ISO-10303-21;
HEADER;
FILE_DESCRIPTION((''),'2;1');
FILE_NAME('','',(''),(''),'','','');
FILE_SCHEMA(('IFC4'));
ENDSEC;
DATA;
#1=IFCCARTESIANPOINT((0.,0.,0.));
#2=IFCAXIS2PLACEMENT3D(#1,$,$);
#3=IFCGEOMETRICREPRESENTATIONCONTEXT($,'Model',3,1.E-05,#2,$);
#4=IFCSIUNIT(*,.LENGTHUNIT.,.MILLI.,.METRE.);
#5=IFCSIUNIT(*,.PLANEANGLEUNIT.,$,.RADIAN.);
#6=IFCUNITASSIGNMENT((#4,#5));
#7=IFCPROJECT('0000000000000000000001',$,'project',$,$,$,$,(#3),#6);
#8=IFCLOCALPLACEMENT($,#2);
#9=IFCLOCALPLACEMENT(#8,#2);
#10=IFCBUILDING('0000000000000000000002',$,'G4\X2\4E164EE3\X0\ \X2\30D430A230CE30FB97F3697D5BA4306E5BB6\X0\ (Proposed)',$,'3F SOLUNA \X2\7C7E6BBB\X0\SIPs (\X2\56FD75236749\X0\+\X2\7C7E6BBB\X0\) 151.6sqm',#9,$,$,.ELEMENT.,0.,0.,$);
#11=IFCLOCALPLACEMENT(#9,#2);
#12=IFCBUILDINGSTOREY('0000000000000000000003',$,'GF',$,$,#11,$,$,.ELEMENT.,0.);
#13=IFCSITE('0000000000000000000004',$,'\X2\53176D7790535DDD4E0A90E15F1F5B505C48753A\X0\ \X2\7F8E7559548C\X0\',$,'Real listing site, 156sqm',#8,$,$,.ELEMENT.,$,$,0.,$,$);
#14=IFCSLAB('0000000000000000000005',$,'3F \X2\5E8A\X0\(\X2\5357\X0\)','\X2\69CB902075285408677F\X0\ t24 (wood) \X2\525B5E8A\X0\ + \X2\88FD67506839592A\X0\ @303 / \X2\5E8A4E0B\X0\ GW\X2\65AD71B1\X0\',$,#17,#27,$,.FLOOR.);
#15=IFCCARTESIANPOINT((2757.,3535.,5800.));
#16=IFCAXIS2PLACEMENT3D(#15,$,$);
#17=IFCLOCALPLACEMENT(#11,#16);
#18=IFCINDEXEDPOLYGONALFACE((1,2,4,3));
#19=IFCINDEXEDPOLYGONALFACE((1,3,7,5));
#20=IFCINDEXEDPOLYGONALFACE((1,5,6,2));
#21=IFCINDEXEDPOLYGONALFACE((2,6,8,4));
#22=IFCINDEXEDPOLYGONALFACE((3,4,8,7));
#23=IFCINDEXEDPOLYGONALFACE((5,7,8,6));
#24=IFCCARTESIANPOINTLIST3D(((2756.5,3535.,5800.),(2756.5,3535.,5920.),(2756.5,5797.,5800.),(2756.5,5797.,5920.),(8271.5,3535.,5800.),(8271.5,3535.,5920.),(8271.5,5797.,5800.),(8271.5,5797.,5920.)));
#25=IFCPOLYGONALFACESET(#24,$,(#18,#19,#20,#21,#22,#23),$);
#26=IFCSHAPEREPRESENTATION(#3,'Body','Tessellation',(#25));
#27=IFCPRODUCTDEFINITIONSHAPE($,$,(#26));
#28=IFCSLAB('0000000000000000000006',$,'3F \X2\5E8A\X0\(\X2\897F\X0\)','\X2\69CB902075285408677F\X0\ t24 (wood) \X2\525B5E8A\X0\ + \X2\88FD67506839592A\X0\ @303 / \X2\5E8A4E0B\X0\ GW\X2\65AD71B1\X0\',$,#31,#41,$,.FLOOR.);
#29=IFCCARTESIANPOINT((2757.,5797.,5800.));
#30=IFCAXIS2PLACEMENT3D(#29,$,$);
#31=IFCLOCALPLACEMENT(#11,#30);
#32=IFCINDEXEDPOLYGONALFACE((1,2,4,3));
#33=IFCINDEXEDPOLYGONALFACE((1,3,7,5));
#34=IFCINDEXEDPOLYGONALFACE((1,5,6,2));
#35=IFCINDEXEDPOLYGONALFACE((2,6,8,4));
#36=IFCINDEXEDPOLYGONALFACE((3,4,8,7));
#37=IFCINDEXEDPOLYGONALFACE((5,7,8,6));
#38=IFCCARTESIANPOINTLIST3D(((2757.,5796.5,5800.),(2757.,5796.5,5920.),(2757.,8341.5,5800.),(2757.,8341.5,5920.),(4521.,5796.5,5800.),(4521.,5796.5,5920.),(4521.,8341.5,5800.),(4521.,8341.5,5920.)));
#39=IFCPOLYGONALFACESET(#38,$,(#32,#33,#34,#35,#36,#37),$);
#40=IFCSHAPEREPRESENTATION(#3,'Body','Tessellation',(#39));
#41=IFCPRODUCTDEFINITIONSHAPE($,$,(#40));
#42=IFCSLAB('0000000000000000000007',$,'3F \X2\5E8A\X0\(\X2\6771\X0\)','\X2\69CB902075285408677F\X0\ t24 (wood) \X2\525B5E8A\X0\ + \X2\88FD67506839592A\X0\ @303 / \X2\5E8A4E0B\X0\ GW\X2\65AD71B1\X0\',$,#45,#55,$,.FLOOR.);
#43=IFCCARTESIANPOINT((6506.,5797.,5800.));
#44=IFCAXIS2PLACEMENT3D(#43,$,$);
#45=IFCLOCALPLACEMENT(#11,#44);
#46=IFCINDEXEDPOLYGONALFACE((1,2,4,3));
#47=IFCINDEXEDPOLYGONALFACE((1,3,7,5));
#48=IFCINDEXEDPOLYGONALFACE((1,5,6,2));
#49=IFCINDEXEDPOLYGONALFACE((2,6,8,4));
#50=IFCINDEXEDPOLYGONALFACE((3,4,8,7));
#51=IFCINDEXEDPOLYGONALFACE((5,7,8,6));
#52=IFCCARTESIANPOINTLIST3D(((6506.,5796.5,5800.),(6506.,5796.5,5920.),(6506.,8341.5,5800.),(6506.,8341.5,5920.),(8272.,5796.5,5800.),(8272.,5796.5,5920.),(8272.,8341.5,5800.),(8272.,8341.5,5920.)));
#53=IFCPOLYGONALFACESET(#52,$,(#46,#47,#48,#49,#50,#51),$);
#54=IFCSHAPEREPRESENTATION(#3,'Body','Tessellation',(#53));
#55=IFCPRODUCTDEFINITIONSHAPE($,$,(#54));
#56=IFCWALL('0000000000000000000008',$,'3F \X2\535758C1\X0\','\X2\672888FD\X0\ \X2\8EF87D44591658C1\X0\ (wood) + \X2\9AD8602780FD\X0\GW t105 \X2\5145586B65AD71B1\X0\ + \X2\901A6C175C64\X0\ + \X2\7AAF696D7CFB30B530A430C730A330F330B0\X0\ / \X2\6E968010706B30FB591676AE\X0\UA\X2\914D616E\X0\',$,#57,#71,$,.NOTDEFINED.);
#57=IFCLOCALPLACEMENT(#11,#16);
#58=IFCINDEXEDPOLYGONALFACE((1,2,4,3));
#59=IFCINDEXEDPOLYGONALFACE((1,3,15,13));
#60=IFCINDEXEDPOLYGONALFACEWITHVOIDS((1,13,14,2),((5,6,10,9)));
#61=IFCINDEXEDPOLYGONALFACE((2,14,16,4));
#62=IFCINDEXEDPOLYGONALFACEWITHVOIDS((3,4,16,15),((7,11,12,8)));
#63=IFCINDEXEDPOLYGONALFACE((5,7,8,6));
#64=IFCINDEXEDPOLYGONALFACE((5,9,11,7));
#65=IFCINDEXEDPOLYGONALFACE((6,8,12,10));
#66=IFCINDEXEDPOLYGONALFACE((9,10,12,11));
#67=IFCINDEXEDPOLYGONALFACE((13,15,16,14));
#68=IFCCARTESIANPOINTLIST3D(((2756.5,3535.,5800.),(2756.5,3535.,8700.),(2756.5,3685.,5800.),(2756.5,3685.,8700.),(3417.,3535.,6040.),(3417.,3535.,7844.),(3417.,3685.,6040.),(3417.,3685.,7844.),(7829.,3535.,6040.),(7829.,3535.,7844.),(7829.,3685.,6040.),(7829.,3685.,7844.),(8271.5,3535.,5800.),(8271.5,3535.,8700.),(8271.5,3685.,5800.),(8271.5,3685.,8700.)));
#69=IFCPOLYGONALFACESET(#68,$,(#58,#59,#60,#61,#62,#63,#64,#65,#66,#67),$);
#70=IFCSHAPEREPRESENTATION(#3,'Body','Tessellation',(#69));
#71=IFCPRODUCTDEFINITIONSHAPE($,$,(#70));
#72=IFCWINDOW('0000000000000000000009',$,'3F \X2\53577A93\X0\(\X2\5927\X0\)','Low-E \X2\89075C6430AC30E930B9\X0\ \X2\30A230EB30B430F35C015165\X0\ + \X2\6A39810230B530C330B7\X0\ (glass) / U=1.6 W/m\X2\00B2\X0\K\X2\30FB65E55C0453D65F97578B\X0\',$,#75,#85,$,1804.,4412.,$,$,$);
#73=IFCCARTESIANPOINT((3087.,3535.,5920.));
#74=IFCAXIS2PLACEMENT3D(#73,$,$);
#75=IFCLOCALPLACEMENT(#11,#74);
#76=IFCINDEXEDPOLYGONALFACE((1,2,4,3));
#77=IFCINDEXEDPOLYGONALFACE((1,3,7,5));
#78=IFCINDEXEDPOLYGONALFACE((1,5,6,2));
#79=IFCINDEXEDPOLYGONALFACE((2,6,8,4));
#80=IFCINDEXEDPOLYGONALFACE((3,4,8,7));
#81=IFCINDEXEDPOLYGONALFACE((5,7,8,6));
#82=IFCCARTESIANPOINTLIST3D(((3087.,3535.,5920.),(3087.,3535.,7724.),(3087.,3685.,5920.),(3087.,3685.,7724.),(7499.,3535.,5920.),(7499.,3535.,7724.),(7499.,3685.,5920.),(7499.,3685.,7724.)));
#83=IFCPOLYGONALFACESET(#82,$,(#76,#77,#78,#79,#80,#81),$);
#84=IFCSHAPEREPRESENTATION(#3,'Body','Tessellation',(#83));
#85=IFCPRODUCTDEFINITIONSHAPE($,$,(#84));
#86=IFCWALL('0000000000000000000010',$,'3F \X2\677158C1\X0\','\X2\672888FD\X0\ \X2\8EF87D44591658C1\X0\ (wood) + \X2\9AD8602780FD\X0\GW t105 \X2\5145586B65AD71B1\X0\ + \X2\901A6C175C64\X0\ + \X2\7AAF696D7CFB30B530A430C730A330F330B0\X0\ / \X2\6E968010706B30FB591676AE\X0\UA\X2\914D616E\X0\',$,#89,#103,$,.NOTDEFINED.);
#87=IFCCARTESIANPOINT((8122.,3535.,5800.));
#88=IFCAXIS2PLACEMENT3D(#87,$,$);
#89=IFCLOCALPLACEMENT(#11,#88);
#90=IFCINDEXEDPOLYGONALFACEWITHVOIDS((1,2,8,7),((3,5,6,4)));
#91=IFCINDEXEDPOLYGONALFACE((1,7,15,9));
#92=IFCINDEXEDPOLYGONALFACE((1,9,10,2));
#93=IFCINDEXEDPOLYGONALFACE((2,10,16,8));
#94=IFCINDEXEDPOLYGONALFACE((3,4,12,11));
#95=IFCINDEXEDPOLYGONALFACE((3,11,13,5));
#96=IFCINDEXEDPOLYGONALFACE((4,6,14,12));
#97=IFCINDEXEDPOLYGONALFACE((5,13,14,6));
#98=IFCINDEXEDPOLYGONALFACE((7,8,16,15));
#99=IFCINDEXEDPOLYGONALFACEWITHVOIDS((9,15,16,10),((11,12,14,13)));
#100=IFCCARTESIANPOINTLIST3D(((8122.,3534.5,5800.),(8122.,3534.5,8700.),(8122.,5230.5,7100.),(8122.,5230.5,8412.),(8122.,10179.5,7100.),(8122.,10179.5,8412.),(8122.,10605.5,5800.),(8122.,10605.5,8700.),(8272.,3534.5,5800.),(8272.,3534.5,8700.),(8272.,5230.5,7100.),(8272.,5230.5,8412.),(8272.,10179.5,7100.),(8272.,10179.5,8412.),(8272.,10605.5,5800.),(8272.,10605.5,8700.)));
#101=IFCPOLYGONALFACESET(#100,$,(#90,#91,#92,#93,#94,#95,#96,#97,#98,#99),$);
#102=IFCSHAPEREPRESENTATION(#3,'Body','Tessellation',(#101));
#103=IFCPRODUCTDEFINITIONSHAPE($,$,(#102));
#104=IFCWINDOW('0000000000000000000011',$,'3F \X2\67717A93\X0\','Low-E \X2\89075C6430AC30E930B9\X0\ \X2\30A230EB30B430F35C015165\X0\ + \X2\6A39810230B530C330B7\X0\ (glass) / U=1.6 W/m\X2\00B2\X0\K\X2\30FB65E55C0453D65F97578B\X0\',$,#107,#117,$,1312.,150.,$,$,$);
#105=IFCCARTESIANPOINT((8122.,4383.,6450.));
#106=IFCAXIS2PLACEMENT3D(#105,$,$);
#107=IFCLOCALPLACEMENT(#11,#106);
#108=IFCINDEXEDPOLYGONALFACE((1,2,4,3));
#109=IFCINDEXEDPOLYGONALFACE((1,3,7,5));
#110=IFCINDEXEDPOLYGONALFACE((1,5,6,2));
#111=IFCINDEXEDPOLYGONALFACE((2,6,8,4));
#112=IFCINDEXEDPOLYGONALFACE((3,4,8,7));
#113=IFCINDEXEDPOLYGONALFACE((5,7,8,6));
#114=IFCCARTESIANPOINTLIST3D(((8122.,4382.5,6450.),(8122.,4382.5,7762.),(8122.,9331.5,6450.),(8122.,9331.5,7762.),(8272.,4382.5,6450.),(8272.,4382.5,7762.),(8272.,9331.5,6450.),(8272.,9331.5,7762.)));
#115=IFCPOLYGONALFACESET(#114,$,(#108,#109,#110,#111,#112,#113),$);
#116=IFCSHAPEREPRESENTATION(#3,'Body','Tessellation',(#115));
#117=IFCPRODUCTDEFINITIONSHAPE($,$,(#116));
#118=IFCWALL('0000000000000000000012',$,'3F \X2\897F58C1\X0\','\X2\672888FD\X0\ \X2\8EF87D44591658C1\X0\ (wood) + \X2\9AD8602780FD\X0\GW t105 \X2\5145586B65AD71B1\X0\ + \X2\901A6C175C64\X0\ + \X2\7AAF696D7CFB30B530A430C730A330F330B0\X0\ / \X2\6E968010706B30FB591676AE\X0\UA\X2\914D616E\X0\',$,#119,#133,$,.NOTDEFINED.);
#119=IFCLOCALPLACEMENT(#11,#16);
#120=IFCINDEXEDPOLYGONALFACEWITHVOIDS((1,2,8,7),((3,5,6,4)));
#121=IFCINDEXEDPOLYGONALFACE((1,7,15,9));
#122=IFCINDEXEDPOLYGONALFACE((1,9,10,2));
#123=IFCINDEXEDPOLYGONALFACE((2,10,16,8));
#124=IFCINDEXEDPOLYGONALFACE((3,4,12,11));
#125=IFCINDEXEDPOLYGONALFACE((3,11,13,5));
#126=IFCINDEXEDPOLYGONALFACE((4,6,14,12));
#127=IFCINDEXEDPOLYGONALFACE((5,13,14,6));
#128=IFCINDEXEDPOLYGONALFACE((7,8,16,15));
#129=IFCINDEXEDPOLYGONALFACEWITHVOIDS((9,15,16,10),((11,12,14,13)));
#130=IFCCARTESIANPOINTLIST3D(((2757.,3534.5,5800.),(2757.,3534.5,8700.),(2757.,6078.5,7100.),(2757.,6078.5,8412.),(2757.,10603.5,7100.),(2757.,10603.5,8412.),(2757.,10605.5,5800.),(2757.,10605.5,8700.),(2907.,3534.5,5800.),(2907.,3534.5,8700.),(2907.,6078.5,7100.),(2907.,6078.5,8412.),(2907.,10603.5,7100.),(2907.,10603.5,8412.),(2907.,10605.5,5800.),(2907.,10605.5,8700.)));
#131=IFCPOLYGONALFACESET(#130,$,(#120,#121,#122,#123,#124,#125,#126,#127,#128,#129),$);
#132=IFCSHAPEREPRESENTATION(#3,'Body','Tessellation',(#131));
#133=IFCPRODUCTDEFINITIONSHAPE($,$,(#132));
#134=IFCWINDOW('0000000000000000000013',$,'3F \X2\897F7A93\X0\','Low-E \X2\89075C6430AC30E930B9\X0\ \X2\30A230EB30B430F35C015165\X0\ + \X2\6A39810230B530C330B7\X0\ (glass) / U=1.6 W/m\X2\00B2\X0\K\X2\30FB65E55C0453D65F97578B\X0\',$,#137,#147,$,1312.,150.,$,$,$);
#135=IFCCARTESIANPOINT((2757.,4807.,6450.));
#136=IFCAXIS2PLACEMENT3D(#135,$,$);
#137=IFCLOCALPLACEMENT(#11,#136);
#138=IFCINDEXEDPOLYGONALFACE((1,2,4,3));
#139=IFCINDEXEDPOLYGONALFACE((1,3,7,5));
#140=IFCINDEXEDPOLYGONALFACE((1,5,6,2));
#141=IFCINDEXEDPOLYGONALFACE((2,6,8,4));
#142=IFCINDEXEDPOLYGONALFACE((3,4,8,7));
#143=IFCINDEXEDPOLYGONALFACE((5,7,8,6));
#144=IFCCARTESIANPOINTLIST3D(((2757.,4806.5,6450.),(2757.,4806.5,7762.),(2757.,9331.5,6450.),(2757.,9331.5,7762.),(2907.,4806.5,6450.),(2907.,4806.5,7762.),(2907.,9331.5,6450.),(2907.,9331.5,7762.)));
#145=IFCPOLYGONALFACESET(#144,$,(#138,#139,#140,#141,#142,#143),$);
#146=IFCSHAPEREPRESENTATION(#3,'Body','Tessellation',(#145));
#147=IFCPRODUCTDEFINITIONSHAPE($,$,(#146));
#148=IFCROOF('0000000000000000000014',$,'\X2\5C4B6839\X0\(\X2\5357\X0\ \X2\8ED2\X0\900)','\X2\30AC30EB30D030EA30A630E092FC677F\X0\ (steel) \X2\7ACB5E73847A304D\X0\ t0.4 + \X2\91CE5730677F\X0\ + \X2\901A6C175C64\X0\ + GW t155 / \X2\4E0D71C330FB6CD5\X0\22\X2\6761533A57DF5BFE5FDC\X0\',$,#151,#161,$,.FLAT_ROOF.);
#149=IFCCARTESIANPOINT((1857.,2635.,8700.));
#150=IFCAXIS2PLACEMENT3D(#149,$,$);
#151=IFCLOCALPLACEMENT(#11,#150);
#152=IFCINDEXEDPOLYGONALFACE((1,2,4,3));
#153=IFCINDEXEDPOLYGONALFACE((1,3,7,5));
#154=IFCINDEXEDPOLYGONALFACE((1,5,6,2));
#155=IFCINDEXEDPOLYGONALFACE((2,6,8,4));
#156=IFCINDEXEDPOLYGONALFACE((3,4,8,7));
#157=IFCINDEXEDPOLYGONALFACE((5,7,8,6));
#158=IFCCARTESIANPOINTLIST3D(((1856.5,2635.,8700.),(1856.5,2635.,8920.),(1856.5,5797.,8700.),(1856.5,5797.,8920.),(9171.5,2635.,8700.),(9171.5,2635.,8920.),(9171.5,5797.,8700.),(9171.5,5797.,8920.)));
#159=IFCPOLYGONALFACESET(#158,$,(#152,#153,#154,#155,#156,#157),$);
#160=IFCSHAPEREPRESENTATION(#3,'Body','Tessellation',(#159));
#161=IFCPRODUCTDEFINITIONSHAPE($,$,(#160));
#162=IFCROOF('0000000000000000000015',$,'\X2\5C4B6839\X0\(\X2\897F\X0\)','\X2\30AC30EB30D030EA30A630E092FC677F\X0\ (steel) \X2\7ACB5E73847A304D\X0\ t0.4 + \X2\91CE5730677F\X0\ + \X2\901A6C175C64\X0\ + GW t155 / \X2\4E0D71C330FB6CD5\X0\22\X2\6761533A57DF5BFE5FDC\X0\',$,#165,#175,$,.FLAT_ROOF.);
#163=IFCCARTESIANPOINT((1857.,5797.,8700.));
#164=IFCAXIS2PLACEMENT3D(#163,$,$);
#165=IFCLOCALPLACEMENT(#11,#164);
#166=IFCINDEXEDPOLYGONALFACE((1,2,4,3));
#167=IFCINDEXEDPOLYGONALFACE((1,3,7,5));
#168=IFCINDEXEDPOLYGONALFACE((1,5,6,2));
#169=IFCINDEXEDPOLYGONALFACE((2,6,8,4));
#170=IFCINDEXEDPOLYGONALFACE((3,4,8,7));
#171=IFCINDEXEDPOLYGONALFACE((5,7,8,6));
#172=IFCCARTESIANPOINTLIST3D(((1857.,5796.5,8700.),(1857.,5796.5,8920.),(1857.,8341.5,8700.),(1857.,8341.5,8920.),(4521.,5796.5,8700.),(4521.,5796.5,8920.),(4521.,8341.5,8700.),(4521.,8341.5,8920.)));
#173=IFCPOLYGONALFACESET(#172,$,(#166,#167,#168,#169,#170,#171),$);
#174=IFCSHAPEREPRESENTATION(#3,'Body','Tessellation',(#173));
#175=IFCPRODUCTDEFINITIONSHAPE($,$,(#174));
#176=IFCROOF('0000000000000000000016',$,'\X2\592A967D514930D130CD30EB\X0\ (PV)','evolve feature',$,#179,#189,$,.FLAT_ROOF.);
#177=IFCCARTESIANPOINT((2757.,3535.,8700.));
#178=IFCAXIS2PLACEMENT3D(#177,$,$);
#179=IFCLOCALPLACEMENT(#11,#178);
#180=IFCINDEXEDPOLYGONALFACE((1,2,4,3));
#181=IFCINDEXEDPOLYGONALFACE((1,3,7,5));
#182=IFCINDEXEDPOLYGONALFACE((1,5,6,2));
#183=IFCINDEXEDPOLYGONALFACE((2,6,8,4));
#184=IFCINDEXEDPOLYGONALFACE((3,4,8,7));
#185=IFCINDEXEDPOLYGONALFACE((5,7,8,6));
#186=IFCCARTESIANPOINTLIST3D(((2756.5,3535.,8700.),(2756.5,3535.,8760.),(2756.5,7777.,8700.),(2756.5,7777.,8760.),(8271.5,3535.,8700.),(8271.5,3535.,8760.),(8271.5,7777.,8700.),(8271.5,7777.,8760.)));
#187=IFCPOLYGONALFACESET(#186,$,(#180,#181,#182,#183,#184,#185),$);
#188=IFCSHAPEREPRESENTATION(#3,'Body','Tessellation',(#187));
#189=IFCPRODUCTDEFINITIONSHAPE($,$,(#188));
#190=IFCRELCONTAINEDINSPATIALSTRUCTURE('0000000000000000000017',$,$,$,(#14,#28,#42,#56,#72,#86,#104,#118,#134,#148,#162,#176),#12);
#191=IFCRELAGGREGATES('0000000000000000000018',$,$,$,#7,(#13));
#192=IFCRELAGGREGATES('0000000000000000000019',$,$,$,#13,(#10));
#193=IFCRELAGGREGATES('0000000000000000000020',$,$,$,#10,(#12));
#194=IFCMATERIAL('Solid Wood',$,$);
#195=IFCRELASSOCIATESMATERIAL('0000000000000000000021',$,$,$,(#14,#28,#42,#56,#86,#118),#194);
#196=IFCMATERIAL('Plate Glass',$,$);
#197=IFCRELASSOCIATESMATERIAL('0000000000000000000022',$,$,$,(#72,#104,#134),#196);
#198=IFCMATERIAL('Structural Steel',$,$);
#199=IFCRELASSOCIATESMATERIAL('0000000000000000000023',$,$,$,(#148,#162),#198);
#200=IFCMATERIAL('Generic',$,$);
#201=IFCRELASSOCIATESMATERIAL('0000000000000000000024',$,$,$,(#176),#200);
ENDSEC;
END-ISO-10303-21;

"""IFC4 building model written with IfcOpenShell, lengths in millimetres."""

from ifc_helpers import new_model, si_unit, frame, frame_2d, origin, place, context, project, spatial, rectangle, extrude, material, element, fill, save


model = new_model("IFC4")

# Units and contexts
model_context = context("Model", 3, precision=1e-05, world=origin())
ifc_project = project(units=[si_unit("LENGTHUNIT", "METRE", prefix="MILLI"), si_unit("PLANEANGLEUNIT", "RADIAN")], contexts=[model_context])

# Site, building, storey
site_placement = place(None, origin())
site = spatial("IfcSite", under=ifc_project, at=site_placement, Name="北海道川上郡弟子屈町 美留和", ObjectType="Real listing site, 156sqm", CompositionType="ELEMENT", RefElevation=0.0)
building_placement = place(site_placement, origin())
building = spatial("IfcBuilding", under=site, at=building_placement, Name="G4世代 ピアノ・音楽室の家 (Proposed)", ObjectType="3F SOLUNA 籾殻SIPs (国産杉+籾殻) 151.6sqm", CompositionType="ELEMENT", ElevationOfRefHeight=0.0, ElevationOfTerrain=0.0)
storey_placement = place(building_placement, origin())
storey = spatial("IfcBuildingStorey", under=building, at=storey_placement, Name="GF", CompositionType="ELEMENT", Elevation=0.0)

# Slabs
ifc_material_1 = material(Name="Solid Wood")
slab_1_placement = place(storey_placement, frame((2757.0, 3535.0, 5800.0)))
element("IfcSlab", 1, at=slab_1_placement, inside=storey, material=ifc_material_1, Name="3F 床(南)", Description="構造用合板 t24 (wood) 剛床 + 製材根太 @303 / 床下 GW断熱", PredefinedType="FLOOR", context=model_context, shape_type="SweptSolid", body=[
    extrude(rectangle(XDim=5515.0, YDim=2262.0, at=frame_2d((2757.0, 1131.0))), frame((2757.0, 3535.0, 5800.0)), (0.0, 0.0, 1.0), 120.0),
])
slab_2_placement = place(storey_placement, frame((2757.0, 5797.0, 5800.0)))
element("IfcSlab", 2, at=slab_2_placement, inside=storey, material=ifc_material_1, Name="3F 床(西)", Description="構造用合板 t24 (wood) 剛床 + 製材根太 @303 / 床下 GW断熱", PredefinedType="FLOOR", context=model_context, shape_type="SweptSolid", body=[
    extrude(rectangle(XDim=1764.0, YDim=2545.0, at=frame_2d((882.0, 1272.0))), frame((2757.0, 5797.0, 5800.0)), (0.0, 0.0, 1.0), 120.0),
])
slab_3_placement = place(storey_placement, frame((6506.0, 5797.0, 5800.0)))
element("IfcSlab", 3, at=slab_3_placement, inside=storey, material=ifc_material_1, Name="3F 床(東)", Description="構造用合板 t24 (wood) 剛床 + 製材根太 @303 / 床下 GW断熱", PredefinedType="FLOOR", context=model_context, shape_type="SweptSolid", body=[
    extrude(rectangle(XDim=1766.0, YDim=2545.0, at=frame_2d((883.0, 1272.0))), frame((6506.0, 5797.0, 5800.0)), (0.0, 0.0, 1.0), 120.0),
])

# Walls, openings, windows
wall_1_placement = place(storey_placement, frame((2757.0, 3535.0, 5800.0)))
wall_1 = element("IfcWall", 4, at=wall_1_placement, inside=storey, material=ifc_material_1, Name="3F 南壁", Description="木製 軸組外壁 (wood) + 高性能GW t105 充填断熱 + 通気層 + 窯業系サイディング / 準耐火・外皮UA配慮", PredefinedType="NOTDEFINED", context=model_context, shape_type="SweptSolid", body=[
    extrude(rectangle(XDim=5515.0, YDim=150.0, at=frame_2d((2757.0, 75.0))), frame((2757.0, 3535.0, 5800.0)), (0.0, 0.0, 1.0), 2900.0),
])
opening_1_placement = place(storey_placement, frame((3087.0, 3535.0, 5920.0)))
opening_1 = element("IfcOpeningElement", 5, at=opening_1_placement, cuts=wall_1, PredefinedType="NOTDEFINED", context=model_context, shape_type="SweptSolid", body=[
    extrude(rectangle(XDim=4412.0, YDim=150.0, at=frame_2d((2206.0, 75.0))), frame((3087.0, 3535.0, 5920.0)), (0.0, 0.0, 1.0), 1804.0),
])
ifc_material_2 = material(Name="Plate Glass")
window_1_placement = place(storey_placement, frame((3087.0, 3535.0, 5920.0)))
window_1 = element("IfcWindow", 6, at=window_1_placement, inside=storey, material=ifc_material_2, Name="3F 南窓(大)", Description="Low-E 複層ガラス アルゴン封入 + 樹脂サッシ (glass) / U=1.6 W/m²K・日射取得型", OverallHeight=1804.0, OverallWidth=4412.0, context=model_context, shape_type="SweptSolid", body=[
    extrude(rectangle(XDim=4412.0, YDim=150.0, at=frame_2d((2206.0, 75.0))), frame((3087.0, 3535.0, 5920.0)), (0.0, 0.0, 1.0), 1804.0),
])
fill(opening_1, window_1)
wall_2_placement = place(storey_placement, frame((8122.0, 3535.0, 5800.0)))
wall_2 = element("IfcWall", 7, at=wall_2_placement, inside=storey, material=ifc_material_1, Name="3F 東壁", Description="木製 軸組外壁 (wood) + 高性能GW t105 充填断熱 + 通気層 + 窯業系サイディング / 準耐火・外皮UA配慮", PredefinedType="NOTDEFINED", context=model_context, shape_type="SweptSolid", body=[
    extrude(rectangle(XDim=150.0, YDim=7071.0, at=frame_2d((75.0, 3535.0))), frame((8122.0, 3535.0, 5800.0)), (0.0, 0.0, 1.0), 2900.0),
])
opening_2_placement = place(storey_placement, frame((8122.0, 4383.0, 6450.0)))
opening_2 = element("IfcOpeningElement", 8, at=opening_2_placement, cuts=wall_2, PredefinedType="NOTDEFINED", context=model_context, shape_type="SweptSolid", body=[
    extrude(rectangle(XDim=150.0, YDim=4949.0, at=frame_2d((75.0, 2474.0))), frame((8122.0, 4383.0, 6450.0)), (0.0, 0.0, 1.0), 1312.0),
])
window_2_placement = place(storey_placement, frame((8122.0, 4383.0, 6450.0)))
window_2 = element("IfcWindow", 9, at=window_2_placement, inside=storey, material=ifc_material_2, Name="3F 東窓", Description="Low-E 複層ガラス アルゴン封入 + 樹脂サッシ (glass) / U=1.6 W/m²K・日射取得型", OverallHeight=1312.0, OverallWidth=150.0, context=model_context, shape_type="SweptSolid", body=[
    extrude(rectangle(XDim=150.0, YDim=4949.0, at=frame_2d((75.0, 2474.0))), frame((8122.0, 4383.0, 6450.0)), (0.0, 0.0, 1.0), 1312.0),
])
fill(opening_2, window_2)
wall_3_placement = place(storey_placement, frame((2757.0, 3535.0, 5800.0)))
wall_3 = element("IfcWall", 10, at=wall_3_placement, inside=storey, material=ifc_material_1, Name="3F 西壁", Description="木製 軸組外壁 (wood) + 高性能GW t105 充填断熱 + 通気層 + 窯業系サイディング / 準耐火・外皮UA配慮", PredefinedType="NOTDEFINED", context=model_context, shape_type="SweptSolid", body=[
    extrude(rectangle(XDim=150.0, YDim=7071.0, at=frame_2d((75.0, 3535.0))), frame((2757.0, 3535.0, 5800.0)), (0.0, 0.0, 1.0), 2900.0),
])
opening_3_placement = place(storey_placement, frame((2757.0, 4807.0, 6450.0)))
opening_3 = element("IfcOpeningElement", 11, at=opening_3_placement, cuts=wall_3, PredefinedType="NOTDEFINED", context=model_context, shape_type="SweptSolid", body=[
    extrude(rectangle(XDim=150.0, YDim=4525.0, at=frame_2d((75.0, 2262.0))), frame((2757.0, 4807.0, 6450.0)), (0.0, 0.0, 1.0), 1312.0),
])
window_3_placement = place(storey_placement, frame((2757.0, 4807.0, 6450.0)))
window_3 = element("IfcWindow", 12, at=window_3_placement, inside=storey, material=ifc_material_2, Name="3F 西窓", Description="Low-E 複層ガラス アルゴン封入 + 樹脂サッシ (glass) / U=1.6 W/m²K・日射取得型", OverallHeight=1312.0, OverallWidth=150.0, context=model_context, shape_type="SweptSolid", body=[
    extrude(rectangle(XDim=150.0, YDim=4525.0, at=frame_2d((75.0, 2262.0))), frame((2757.0, 4807.0, 6450.0)), (0.0, 0.0, 1.0), 1312.0),
])
fill(opening_3, window_3)

# Roofs
ifc_material_3 = material(Name="Structural Steel")
roof_1_placement = place(storey_placement, frame((1857.0, 2635.0, 8700.0)))
element("IfcRoof", 13, at=roof_1_placement, inside=storey, material=ifc_material_3, Name="屋根(南 軒900)", Description="ガルバリウム鋼板 (steel) 立平葺き t0.4 + 野地板 + 通気層 + GW t155 / 不燃・法22条区域対応", PredefinedType="FLAT_ROOF", context=model_context, shape_type="SweptSolid", body=[
    extrude(rectangle(XDim=7315.0, YDim=3162.0, at=frame_2d((3657.0, 1581.0))), frame((1857.0, 2635.0, 8700.0)), (0.0, 0.0, 1.0), 220.0),
])
roof_2_placement = place(storey_placement, frame((1857.0, 5797.0, 8700.0)))
element("IfcRoof", 14, at=roof_2_placement, inside=storey, material=ifc_material_3, Name="屋根(西)", Description="ガルバリウム鋼板 (steel) 立平葺き t0.4 + 野地板 + 通気層 + GW t155 / 不燃・法22条区域対応", PredefinedType="FLAT_ROOF", context=model_context, shape_type="SweptSolid", body=[
    extrude(rectangle(XDim=2664.0, YDim=2545.0, at=frame_2d((1332.0, 1272.0))), frame((1857.0, 5797.0, 8700.0)), (0.0, 0.0, 1.0), 220.0),
])
ifc_material_4 = material(Name="Generic")
roof_3_placement = place(storey_placement, frame((2757.0, 3535.0, 8700.0)))
element("IfcRoof", 15, at=roof_3_placement, inside=storey, material=ifc_material_4, Name="太陽光パネル (PV)", Description="evolve feature", PredefinedType="FLAT_ROOF", context=model_context, shape_type="SweptSolid", body=[
    extrude(rectangle(XDim=5515.0, YDim=4242.0, at=frame_2d((2757.0, 2121.0))), frame((2757.0, 3535.0, 8700.0)), (0.0, 0.0, 1.0), 60.0),
])

save(model, "model.ifc")
